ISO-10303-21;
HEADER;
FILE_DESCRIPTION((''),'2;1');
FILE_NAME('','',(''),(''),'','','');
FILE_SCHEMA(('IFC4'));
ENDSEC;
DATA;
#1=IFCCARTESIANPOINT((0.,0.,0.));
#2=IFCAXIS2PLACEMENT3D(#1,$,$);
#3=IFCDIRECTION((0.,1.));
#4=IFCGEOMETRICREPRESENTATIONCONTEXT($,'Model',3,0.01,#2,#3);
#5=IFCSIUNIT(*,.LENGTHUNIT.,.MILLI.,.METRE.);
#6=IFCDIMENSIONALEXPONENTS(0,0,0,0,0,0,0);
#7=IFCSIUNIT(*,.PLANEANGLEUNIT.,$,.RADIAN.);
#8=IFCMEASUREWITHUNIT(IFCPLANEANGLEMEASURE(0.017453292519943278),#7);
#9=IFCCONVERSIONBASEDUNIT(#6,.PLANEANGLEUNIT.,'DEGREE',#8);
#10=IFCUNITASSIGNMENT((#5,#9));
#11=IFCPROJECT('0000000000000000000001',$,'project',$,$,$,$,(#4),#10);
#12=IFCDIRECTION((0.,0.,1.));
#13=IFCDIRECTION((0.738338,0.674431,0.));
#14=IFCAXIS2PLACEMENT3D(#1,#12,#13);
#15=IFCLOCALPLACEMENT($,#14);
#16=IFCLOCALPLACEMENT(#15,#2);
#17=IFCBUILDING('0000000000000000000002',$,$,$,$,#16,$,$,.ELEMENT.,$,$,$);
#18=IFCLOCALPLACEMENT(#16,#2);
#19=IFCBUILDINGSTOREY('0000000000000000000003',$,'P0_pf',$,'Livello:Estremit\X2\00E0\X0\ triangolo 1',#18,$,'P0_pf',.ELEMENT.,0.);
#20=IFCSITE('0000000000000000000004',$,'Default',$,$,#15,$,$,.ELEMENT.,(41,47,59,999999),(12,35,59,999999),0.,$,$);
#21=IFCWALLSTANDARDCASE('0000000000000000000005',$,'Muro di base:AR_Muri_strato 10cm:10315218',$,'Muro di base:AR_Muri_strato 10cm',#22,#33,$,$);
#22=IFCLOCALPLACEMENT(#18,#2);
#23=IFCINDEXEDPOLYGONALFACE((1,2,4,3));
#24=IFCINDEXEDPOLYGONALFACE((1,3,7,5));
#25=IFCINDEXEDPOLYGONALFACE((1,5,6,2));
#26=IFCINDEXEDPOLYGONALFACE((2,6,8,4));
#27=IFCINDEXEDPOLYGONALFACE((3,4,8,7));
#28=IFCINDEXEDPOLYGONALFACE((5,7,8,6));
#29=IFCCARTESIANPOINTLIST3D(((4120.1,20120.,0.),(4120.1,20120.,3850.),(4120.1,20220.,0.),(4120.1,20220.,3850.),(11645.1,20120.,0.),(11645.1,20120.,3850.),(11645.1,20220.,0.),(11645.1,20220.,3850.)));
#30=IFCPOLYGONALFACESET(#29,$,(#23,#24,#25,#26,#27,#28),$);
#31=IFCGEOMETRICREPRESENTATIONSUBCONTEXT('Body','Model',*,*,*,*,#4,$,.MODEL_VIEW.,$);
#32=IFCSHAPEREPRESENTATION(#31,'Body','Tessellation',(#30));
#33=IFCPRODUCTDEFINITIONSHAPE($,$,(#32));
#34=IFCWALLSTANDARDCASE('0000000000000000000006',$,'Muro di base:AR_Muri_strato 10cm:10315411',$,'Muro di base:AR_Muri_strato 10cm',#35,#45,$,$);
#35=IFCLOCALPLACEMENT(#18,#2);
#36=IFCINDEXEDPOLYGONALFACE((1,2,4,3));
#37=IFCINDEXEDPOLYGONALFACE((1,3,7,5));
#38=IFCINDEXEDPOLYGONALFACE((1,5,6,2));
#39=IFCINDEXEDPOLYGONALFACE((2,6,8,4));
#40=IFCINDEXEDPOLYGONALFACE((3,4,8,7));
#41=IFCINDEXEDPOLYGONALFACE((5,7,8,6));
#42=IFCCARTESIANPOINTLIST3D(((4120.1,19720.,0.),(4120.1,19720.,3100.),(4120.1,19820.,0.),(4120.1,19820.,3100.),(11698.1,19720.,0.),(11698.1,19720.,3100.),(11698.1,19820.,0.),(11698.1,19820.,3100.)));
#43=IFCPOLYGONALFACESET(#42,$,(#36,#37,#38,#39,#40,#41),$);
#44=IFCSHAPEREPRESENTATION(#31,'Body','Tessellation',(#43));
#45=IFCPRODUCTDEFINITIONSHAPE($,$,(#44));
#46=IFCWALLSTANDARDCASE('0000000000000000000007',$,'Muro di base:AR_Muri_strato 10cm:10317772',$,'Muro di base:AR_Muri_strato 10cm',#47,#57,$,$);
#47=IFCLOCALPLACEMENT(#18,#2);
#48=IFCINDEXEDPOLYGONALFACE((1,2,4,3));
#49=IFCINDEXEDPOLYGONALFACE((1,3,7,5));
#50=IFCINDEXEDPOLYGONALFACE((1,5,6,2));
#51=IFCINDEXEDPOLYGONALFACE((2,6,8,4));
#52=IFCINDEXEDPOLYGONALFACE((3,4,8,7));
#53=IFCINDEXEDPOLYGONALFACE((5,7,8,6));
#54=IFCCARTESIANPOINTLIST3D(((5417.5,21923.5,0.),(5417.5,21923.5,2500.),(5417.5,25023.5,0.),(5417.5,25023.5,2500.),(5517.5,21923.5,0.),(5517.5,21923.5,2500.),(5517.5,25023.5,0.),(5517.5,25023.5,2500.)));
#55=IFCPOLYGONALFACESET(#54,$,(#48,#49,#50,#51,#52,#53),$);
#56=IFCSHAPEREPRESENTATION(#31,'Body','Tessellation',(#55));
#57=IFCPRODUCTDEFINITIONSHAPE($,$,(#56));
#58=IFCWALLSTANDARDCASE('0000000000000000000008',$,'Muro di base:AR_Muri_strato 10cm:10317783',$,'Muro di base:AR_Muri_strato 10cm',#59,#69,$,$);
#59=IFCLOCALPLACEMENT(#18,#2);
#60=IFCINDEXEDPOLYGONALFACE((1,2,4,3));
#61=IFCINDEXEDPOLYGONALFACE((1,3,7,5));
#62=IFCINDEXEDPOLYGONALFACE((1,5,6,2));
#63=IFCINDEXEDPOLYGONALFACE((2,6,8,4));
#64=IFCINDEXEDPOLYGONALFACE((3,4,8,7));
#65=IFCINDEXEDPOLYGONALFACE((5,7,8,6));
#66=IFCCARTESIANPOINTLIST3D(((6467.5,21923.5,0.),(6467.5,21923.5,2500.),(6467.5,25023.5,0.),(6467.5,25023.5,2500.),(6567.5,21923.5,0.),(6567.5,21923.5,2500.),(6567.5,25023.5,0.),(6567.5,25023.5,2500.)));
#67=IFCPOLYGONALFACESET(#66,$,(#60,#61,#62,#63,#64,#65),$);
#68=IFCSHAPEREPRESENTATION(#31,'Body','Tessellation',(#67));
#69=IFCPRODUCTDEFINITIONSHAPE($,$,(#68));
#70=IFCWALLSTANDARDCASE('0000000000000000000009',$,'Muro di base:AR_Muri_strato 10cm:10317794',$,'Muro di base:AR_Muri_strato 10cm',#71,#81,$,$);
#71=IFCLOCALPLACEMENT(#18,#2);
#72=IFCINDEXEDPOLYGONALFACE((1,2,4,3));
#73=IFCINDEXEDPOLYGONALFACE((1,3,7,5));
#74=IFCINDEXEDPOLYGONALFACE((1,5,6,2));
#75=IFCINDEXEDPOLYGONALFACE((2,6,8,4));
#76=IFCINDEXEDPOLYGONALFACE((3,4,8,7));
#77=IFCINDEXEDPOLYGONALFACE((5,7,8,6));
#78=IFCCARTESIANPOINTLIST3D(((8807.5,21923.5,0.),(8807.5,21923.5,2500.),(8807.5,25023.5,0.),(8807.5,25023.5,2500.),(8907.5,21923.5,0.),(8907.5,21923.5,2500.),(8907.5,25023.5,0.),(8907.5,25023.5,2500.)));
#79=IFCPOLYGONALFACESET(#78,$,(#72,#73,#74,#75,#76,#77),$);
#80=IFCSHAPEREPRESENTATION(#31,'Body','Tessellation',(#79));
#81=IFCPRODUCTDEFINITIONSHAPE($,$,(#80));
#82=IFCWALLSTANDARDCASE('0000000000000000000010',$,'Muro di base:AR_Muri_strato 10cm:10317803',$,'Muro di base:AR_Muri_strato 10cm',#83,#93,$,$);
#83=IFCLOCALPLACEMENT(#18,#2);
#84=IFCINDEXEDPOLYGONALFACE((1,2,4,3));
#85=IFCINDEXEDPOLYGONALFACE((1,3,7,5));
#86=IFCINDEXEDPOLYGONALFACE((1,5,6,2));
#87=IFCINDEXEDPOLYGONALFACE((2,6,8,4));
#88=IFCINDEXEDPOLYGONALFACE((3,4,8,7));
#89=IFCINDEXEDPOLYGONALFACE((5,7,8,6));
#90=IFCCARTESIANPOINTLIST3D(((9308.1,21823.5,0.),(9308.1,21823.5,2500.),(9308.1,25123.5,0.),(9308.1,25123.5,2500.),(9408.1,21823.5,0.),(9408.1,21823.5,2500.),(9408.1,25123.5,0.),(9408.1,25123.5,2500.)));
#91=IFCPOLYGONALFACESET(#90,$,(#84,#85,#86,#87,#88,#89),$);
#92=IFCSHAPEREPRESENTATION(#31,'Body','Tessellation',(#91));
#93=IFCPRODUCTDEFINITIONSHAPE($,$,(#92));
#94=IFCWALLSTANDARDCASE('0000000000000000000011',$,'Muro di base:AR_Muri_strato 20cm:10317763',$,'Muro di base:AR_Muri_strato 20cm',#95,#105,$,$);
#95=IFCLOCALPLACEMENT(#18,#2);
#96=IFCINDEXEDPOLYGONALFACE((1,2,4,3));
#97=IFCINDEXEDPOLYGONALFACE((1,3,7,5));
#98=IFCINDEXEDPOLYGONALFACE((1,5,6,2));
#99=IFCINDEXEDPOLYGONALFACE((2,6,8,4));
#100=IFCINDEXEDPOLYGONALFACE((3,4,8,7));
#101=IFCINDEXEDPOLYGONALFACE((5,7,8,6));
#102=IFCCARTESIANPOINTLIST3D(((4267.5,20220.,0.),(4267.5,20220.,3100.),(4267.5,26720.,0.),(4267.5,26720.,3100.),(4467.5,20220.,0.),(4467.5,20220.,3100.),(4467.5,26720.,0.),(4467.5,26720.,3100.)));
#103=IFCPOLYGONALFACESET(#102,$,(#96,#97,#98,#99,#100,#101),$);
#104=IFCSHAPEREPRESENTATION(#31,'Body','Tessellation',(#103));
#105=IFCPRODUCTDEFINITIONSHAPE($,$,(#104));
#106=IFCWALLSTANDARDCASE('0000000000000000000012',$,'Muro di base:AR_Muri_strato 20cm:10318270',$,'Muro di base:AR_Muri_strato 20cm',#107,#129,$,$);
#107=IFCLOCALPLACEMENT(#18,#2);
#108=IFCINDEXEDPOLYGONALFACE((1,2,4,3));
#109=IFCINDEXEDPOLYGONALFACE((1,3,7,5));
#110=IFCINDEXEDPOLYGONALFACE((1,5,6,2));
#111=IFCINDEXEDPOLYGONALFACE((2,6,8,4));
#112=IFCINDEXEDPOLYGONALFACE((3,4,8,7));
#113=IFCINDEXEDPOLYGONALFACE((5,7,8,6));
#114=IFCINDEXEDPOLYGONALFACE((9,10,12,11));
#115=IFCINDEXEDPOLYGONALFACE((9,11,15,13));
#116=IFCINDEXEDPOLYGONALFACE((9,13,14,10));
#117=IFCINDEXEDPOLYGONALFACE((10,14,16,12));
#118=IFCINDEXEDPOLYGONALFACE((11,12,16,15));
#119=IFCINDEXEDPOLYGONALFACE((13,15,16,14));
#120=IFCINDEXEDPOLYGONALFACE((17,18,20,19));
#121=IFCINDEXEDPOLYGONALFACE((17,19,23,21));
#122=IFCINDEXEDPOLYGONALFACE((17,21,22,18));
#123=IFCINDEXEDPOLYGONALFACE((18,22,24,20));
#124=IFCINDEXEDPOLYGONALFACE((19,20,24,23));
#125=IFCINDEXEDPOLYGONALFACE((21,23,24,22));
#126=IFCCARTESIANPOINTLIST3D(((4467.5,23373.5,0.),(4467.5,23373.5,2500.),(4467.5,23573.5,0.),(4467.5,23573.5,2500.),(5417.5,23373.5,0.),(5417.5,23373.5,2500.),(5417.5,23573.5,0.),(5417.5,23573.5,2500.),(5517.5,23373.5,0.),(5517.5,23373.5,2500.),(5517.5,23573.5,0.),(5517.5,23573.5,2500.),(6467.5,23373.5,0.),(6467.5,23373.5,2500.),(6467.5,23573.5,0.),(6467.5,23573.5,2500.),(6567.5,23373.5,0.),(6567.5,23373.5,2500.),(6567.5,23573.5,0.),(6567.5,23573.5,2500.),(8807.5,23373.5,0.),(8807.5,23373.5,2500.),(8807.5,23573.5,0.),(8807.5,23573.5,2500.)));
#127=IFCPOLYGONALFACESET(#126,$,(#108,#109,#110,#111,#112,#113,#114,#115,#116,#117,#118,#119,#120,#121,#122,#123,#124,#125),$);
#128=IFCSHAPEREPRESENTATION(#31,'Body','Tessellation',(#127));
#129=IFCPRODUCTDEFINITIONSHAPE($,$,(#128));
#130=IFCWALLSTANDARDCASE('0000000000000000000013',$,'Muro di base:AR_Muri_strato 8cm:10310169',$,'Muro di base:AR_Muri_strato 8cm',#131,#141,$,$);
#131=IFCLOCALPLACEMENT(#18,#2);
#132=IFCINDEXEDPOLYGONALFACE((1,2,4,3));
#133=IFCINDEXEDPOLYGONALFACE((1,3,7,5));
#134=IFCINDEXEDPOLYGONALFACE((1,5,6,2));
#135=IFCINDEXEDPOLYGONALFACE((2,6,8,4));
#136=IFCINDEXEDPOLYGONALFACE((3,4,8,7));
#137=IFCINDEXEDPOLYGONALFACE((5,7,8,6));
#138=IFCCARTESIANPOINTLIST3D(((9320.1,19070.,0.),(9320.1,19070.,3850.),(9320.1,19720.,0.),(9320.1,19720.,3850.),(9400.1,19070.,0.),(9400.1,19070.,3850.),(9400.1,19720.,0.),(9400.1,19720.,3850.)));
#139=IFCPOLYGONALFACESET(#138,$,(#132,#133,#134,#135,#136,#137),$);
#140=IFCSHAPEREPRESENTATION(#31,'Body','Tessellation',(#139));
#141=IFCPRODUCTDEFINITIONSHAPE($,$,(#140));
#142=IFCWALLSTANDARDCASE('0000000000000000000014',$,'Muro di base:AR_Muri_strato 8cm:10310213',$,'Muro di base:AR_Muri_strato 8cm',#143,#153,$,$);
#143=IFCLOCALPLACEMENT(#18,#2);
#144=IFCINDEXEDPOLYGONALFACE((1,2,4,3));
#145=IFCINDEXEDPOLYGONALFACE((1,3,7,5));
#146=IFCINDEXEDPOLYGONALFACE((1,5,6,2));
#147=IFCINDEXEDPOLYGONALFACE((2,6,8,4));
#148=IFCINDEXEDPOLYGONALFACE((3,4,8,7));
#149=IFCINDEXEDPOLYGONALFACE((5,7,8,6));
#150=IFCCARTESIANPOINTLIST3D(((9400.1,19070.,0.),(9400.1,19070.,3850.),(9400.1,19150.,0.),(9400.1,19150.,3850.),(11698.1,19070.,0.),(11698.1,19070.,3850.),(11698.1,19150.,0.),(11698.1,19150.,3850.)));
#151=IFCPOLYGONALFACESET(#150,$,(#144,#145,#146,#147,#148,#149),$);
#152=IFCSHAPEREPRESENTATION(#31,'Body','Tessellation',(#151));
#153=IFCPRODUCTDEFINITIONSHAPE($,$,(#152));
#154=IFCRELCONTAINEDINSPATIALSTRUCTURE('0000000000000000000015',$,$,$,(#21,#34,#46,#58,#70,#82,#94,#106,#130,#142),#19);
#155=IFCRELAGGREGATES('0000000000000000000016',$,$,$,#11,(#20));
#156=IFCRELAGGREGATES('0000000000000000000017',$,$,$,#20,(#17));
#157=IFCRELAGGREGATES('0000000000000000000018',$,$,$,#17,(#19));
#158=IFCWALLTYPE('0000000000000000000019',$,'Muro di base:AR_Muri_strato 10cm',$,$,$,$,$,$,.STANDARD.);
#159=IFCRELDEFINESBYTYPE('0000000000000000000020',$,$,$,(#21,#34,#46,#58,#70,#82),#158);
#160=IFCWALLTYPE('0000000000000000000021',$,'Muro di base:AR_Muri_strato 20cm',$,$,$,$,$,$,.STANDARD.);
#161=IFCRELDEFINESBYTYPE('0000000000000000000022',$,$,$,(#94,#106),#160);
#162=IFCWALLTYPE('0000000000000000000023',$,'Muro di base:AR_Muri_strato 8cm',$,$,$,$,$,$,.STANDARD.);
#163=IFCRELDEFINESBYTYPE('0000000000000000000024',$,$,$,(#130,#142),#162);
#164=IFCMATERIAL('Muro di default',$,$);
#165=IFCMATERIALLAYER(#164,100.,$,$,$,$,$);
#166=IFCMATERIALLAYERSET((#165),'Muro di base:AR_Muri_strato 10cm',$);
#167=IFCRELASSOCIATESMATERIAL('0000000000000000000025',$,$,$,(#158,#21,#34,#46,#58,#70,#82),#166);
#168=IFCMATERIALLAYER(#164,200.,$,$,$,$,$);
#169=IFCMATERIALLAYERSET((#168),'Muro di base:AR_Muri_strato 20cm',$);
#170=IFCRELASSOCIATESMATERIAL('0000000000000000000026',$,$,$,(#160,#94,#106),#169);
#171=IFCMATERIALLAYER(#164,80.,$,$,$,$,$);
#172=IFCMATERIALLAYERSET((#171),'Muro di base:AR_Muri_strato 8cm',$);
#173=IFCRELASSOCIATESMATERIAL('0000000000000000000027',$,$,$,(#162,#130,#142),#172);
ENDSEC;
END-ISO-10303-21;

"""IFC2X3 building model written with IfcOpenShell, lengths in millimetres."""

from ifc_helpers import new_model, entity, si_unit, converted_unit, direction, frame, frame_2d, origin, origin_2d_with_axis, place, context, subcontext, project, spatial, rectangle, extrude, material, layer, layer_set, layer_usage, type_object, element, save


model = new_model("IFC2X3")

# Units and contexts
model_context = context("Model", 3, precision=0.01, world=origin(), true_north=direction((0.0, 1.0)))
body_context = subcontext(model_context, "Body", "Model", "MODEL_VIEW")
ifc_project = project(units=[si_unit("LENGTHUNIT", "METRE", prefix="MILLI"), converted_unit("PLANEANGLEUNIT", "DEGREE", entity("IfcPlaneAngleMeasure", 0.017453292519943278), si_unit("PLANEANGLEUNIT", "RADIAN"), dimensions=[0, 0, 0, 0, 0, 0, 0])], contexts=[model_context])

# Site, building, storey
site_placement = place(None, frame((0.0, 0.0, 0.0), z_axis=(0.0, 0.0, 1.0), x_axis=(0.738338, 0.674431, 0.0)))
site = spatial("IfcSite", under=ifc_project, at=site_placement, Name="Default", CompositionType="ELEMENT", RefLatitude=(41, 47, 59, 999999), RefLongitude=(12, 35, 59, 999999), RefElevation=0.0)
building_placement = place(site_placement, origin())
building = spatial("IfcBuilding", under=site, at=building_placement, CompositionType="ELEMENT")
storey_placement = place(building_placement, origin())
storey = spatial("IfcBuildingStorey", under=building, at=storey_placement, Name="P0_pf", ObjectType="Livello:Estremità triangolo 1", LongName="P0_pf", CompositionType="ELEMENT", Elevation=0.0)

# Walls
ifc_material_1 = material(Name="Muro di default")
ifc_layer_1 = layer(ifc_material_1, 100.0)
ifc_layer_set_1 = layer_set([ifc_layer_1], Name="Muro di base:AR_Muri_strato 10cm")
wall_type_1 = type_object("IfcWallType", Name="Muro di base:AR_Muri_strato 10cm", PredefinedType="STANDARD", material=ifc_layer_set_1)
ifc_layer_usage_1 = layer_usage(ifc_layer_set_1, "AXIS2", "NEGATIVE", 50.0)
wall_1_placement = place(storey_placement, frame((4120.1, 20170.0, 0.0)))
element("IfcWallStandardCase", 1, at=wall_1_placement, inside=storey, type_object=wall_type_1, material=ifc_layer_usage_1, Name="Muro di base:AR_Muri_strato 10cm:10315218", ObjectType="Muro di base:AR_Muri_strato 10cm", context=body_context, shape_type="SweptSolid", body=[
    extrude(rectangle(XDim=7525.0, YDim=100.0, at=frame_2d((3762.5, 0.0), x_axis=(-1.0, 0.0))), origin(), (0.0, 0.0, 1.0), 3850.0),
])
ifc_layer_usage_2 = layer_usage(ifc_layer_set_1, "AXIS2", "POSITIVE", -50.0)
wall_2_placement = place(storey_placement, frame((4120.1, 19770.0, 0.0)))
element("IfcWallStandardCase", 2, at=wall_2_placement, inside=storey, type_object=wall_type_1, material=ifc_layer_usage_2, Name="Muro di base:AR_Muri_strato 10cm:10315411", ObjectType="Muro di base:AR_Muri_strato 10cm", context=body_context, shape_type="SweptSolid", body=[
    extrude(rectangle(XDim=7578.0, YDim=100.0, at=frame_2d((3789.0, 0.0), x_axis=(-1.0, 0.0))), origin(), (0.0, 0.0, 1.0), 3100.0),
])
ifc_layer_usage_3 = layer_usage(ifc_layer_set_1, "AXIS2", "NEGATIVE", 50.0)
wall_3_placement = place(storey_placement, frame((5467.5, 21923.5, 0.0), z_axis=(0.0, 0.0, 1.0), x_axis=(0.0, 1.0, 0.0)))
element("IfcWallStandardCase", 3, at=wall_3_placement, inside=storey, type_object=wall_type_1, material=ifc_layer_usage_3, Name="Muro di base:AR_Muri_strato 10cm:10317772", ObjectType="Muro di base:AR_Muri_strato 10cm", context=body_context, shape_type="SweptSolid", body=[
    extrude(rectangle(XDim=3100.0, YDim=100.0, at=frame_2d((1550.0, 0.0), x_axis=(-1.0, 0.0))), origin(), (0.0, 0.0, 1.0), 2500.0),
])
ifc_layer_usage_4 = layer_usage(ifc_layer_set_1, "AXIS2", "NEGATIVE", 50.0)
wall_4_placement = place(storey_placement, frame((6517.5, 21923.5, 0.0), z_axis=(0.0, 0.0, 1.0), x_axis=(0.0, 1.0, 0.0)))
element("IfcWallStandardCase", 4, at=wall_4_placement, inside=storey, type_object=wall_type_1, material=ifc_layer_usage_4, Name="Muro di base:AR_Muri_strato 10cm:10317783", ObjectType="Muro di base:AR_Muri_strato 10cm", context=body_context, shape_type="SweptSolid", body=[
    extrude(rectangle(XDim=3100.0, YDim=100.0, at=frame_2d((1550.0, 0.0), x_axis=(-1.0, 0.0))), origin(), (0.0, 0.0, 1.0), 2500.0),
])
ifc_layer_usage_5 = layer_usage(ifc_layer_set_1, "AXIS2", "NEGATIVE", 50.0)
wall_5_placement = place(storey_placement, frame((8857.5, 21923.5, 0.0), z_axis=(0.0, 0.0, 1.0), x_axis=(0.0, 1.0, 0.0)))
element("IfcWallStandardCase", 5, at=wall_5_placement, inside=storey, type_object=wall_type_1, material=ifc_layer_usage_5, Name="Muro di base:AR_Muri_strato 10cm:10317794", ObjectType="Muro di base:AR_Muri_strato 10cm", context=body_context, shape_type="SweptSolid", body=[
    extrude(rectangle(XDim=3100.0, YDim=100.0, at=frame_2d((1550.0, 0.0), x_axis=(-1.0, 0.0))), origin(), (0.0, 0.0, 1.0), 2500.0),
])
ifc_layer_usage_6 = layer_usage(ifc_layer_set_1, "AXIS2", "NEGATIVE", 50.0)
wall_6_placement = place(storey_placement, frame((9358.1, 21823.5, 0.0), z_axis=(0.0, 0.0, 1.0), x_axis=(0.0, 1.0, 0.0)))
element("IfcWallStandardCase", 6, at=wall_6_placement, inside=storey, type_object=wall_type_1, material=ifc_layer_usage_6, Name="Muro di base:AR_Muri_strato 10cm:10317803", ObjectType="Muro di base:AR_Muri_strato 10cm", context=body_context, shape_type="SweptSolid", body=[
    extrude(rectangle(XDim=3300.0, YDim=100.0, at=frame_2d((1650.0, 0.0), x_axis=(-1.0, 0.0))), origin(), (0.0, 0.0, 1.0), 2500.0),
])
ifc_layer_2 = layer(ifc_material_1, 200.0)
ifc_layer_set_2 = layer_set([ifc_layer_2], Name="Muro di base:AR_Muri_strato 20cm")
ifc_layer_usage_7 = layer_usage(ifc_layer_set_2, "AXIS2", "NEGATIVE", 100.0)
wall_type_2 = type_object("IfcWallType", Name="Muro di base:AR_Muri_strato 20cm", PredefinedType="STANDARD", material=ifc_layer_set_2)
wall_7_placement = place(storey_placement, frame((4367.5, 20220.0, 0.0), z_axis=(0.0, 0.0, 1.0), x_axis=(0.0, 1.0, 0.0)))
element("IfcWallStandardCase", 7, at=wall_7_placement, inside=storey, type_object=wall_type_2, material=ifc_layer_usage_7, Name="Muro di base:AR_Muri_strato 20cm:10317763", ObjectType="Muro di base:AR_Muri_strato 20cm", context=body_context, shape_type="SweptSolid", body=[
    extrude(rectangle(XDim=6500.0, YDim=200.0, at=frame_2d((3250.0, 0.0), x_axis=(-1.0, 0.0))), origin(), (0.0, 0.0, 1.0), 3100.0),
])

# Wall, openings
ifc_layer_usage_8 = layer_usage(ifc_layer_set_2, "AXIS2", "NEGATIVE", 100.0)
wall_8_placement = place(storey_placement, frame((8807.5, 23473.5, 0.0), z_axis=(0.0, 0.0, 1.0), x_axis=(-1.0, 0.0, 0.0)))
wall_8 = element("IfcWallStandardCase", 8, at=wall_8_placement, inside=storey, type_object=wall_type_2, material=ifc_layer_usage_8, Name="Muro di base:AR_Muri_strato 20cm:10318270", ObjectType="Muro di base:AR_Muri_strato 20cm", context=body_context, shape_type="SweptSolid", body=[
    extrude(rectangle(XDim=4340.0, YDim=200.0, at=frame_2d((2170.0, 0.0), x_axis=(-1.0, 0.0))), origin(), (0.0, 0.0, 1.0), 2500.0),
])
opening_1_placement = place(storey_placement, frame((8807.5, 23473.5, 0.0), z_axis=(0.0, 0.0, 1.0), x_axis=(-1.0, 0.0, 0.0)))
element("IfcOpeningElement", 9, at=opening_1_placement, cuts=wall_8, ObjectType="Opening", context=body_context, shape_type="SweptSolid", body=[
    extrude(rectangle(XDim=2500.0, YDim=200.0, at=frame_2d((0.0, 0.0), x_axis=(1.0, 0.0))), frame((2340.0, 0.0, 1250.0), z_axis=(-1.0, 0.0, 0.0), x_axis=(0.0, 0.0, 1.0)), (0.0, 0.0, 1.0), 100.0),
])
opening_2_placement = place(storey_placement, frame((8807.5, 23473.5, 0.0), z_axis=(0.0, 0.0, 1.0), x_axis=(-1.0, 0.0, 0.0)))
element("IfcOpeningElement", 10, at=opening_2_placement, cuts=wall_8, ObjectType="Opening", context=body_context, shape_type="SweptSolid", body=[
    extrude(rectangle(XDim=2500.0, YDim=200.0, at=origin_2d_with_axis()), frame((3390.0, 0.0, 1250.0), z_axis=(-1.0, 0.0, 0.0), x_axis=(0.0, 0.0, 1.0)), (0.0, 0.0, 1.0), 100.0),
])

# Walls
ifc_layer_3 = layer(ifc_material_1, 80.0)
ifc_layer_set_3 = layer_set([ifc_layer_3], Name="Muro di base:AR_Muri_strato 8cm")
ifc_layer_usage_9 = layer_usage(ifc_layer_set_3, "AXIS2", "NEGATIVE", 40.0)
wall_type_3 = type_object("IfcWallType", Name="Muro di base:AR_Muri_strato 8cm", PredefinedType="STANDARD", material=ifc_layer_set_3)
wall_9_placement = place(storey_placement, frame((9360.1, 19720.0, 0.0), z_axis=(0.0, 0.0, 1.0), x_axis=(0.0, -1.0, 0.0)))
element("IfcWallStandardCase", 11, at=wall_9_placement, inside=storey, type_object=wall_type_3, material=ifc_layer_usage_9, Name="Muro di base:AR_Muri_strato 8cm:10310169", ObjectType="Muro di base:AR_Muri_strato 8cm", context=body_context, shape_type="SweptSolid", body=[
    extrude(rectangle(XDim=650.0, YDim=80.0, at=frame_2d((325.0, 0.0), x_axis=(-1.0, 0.0))), origin(), (0.0, 0.0, 1.0), 3850.0),
])
ifc_layer_usage_10 = layer_usage(ifc_layer_set_3, "AXIS2", "NEGATIVE", 40.0)
wall_10_placement = place(storey_placement, frame((9400.1, 19110.0, 0.0)))
element("IfcWallStandardCase", 12, at=wall_10_placement, inside=storey, type_object=wall_type_3, material=ifc_layer_usage_10, Name="Muro di base:AR_Muri_strato 8cm:10310213", ObjectType="Muro di base:AR_Muri_strato 8cm", context=body_context, shape_type="SweptSolid", body=[
    extrude(rectangle(XDim=2298.0, YDim=80.0, at=frame_2d((1149.0, 0.0), x_axis=(-1.0, 0.0))), origin(), (0.0, 0.0, 1.0), 3850.0),
])

save(model, "model.ifc")
